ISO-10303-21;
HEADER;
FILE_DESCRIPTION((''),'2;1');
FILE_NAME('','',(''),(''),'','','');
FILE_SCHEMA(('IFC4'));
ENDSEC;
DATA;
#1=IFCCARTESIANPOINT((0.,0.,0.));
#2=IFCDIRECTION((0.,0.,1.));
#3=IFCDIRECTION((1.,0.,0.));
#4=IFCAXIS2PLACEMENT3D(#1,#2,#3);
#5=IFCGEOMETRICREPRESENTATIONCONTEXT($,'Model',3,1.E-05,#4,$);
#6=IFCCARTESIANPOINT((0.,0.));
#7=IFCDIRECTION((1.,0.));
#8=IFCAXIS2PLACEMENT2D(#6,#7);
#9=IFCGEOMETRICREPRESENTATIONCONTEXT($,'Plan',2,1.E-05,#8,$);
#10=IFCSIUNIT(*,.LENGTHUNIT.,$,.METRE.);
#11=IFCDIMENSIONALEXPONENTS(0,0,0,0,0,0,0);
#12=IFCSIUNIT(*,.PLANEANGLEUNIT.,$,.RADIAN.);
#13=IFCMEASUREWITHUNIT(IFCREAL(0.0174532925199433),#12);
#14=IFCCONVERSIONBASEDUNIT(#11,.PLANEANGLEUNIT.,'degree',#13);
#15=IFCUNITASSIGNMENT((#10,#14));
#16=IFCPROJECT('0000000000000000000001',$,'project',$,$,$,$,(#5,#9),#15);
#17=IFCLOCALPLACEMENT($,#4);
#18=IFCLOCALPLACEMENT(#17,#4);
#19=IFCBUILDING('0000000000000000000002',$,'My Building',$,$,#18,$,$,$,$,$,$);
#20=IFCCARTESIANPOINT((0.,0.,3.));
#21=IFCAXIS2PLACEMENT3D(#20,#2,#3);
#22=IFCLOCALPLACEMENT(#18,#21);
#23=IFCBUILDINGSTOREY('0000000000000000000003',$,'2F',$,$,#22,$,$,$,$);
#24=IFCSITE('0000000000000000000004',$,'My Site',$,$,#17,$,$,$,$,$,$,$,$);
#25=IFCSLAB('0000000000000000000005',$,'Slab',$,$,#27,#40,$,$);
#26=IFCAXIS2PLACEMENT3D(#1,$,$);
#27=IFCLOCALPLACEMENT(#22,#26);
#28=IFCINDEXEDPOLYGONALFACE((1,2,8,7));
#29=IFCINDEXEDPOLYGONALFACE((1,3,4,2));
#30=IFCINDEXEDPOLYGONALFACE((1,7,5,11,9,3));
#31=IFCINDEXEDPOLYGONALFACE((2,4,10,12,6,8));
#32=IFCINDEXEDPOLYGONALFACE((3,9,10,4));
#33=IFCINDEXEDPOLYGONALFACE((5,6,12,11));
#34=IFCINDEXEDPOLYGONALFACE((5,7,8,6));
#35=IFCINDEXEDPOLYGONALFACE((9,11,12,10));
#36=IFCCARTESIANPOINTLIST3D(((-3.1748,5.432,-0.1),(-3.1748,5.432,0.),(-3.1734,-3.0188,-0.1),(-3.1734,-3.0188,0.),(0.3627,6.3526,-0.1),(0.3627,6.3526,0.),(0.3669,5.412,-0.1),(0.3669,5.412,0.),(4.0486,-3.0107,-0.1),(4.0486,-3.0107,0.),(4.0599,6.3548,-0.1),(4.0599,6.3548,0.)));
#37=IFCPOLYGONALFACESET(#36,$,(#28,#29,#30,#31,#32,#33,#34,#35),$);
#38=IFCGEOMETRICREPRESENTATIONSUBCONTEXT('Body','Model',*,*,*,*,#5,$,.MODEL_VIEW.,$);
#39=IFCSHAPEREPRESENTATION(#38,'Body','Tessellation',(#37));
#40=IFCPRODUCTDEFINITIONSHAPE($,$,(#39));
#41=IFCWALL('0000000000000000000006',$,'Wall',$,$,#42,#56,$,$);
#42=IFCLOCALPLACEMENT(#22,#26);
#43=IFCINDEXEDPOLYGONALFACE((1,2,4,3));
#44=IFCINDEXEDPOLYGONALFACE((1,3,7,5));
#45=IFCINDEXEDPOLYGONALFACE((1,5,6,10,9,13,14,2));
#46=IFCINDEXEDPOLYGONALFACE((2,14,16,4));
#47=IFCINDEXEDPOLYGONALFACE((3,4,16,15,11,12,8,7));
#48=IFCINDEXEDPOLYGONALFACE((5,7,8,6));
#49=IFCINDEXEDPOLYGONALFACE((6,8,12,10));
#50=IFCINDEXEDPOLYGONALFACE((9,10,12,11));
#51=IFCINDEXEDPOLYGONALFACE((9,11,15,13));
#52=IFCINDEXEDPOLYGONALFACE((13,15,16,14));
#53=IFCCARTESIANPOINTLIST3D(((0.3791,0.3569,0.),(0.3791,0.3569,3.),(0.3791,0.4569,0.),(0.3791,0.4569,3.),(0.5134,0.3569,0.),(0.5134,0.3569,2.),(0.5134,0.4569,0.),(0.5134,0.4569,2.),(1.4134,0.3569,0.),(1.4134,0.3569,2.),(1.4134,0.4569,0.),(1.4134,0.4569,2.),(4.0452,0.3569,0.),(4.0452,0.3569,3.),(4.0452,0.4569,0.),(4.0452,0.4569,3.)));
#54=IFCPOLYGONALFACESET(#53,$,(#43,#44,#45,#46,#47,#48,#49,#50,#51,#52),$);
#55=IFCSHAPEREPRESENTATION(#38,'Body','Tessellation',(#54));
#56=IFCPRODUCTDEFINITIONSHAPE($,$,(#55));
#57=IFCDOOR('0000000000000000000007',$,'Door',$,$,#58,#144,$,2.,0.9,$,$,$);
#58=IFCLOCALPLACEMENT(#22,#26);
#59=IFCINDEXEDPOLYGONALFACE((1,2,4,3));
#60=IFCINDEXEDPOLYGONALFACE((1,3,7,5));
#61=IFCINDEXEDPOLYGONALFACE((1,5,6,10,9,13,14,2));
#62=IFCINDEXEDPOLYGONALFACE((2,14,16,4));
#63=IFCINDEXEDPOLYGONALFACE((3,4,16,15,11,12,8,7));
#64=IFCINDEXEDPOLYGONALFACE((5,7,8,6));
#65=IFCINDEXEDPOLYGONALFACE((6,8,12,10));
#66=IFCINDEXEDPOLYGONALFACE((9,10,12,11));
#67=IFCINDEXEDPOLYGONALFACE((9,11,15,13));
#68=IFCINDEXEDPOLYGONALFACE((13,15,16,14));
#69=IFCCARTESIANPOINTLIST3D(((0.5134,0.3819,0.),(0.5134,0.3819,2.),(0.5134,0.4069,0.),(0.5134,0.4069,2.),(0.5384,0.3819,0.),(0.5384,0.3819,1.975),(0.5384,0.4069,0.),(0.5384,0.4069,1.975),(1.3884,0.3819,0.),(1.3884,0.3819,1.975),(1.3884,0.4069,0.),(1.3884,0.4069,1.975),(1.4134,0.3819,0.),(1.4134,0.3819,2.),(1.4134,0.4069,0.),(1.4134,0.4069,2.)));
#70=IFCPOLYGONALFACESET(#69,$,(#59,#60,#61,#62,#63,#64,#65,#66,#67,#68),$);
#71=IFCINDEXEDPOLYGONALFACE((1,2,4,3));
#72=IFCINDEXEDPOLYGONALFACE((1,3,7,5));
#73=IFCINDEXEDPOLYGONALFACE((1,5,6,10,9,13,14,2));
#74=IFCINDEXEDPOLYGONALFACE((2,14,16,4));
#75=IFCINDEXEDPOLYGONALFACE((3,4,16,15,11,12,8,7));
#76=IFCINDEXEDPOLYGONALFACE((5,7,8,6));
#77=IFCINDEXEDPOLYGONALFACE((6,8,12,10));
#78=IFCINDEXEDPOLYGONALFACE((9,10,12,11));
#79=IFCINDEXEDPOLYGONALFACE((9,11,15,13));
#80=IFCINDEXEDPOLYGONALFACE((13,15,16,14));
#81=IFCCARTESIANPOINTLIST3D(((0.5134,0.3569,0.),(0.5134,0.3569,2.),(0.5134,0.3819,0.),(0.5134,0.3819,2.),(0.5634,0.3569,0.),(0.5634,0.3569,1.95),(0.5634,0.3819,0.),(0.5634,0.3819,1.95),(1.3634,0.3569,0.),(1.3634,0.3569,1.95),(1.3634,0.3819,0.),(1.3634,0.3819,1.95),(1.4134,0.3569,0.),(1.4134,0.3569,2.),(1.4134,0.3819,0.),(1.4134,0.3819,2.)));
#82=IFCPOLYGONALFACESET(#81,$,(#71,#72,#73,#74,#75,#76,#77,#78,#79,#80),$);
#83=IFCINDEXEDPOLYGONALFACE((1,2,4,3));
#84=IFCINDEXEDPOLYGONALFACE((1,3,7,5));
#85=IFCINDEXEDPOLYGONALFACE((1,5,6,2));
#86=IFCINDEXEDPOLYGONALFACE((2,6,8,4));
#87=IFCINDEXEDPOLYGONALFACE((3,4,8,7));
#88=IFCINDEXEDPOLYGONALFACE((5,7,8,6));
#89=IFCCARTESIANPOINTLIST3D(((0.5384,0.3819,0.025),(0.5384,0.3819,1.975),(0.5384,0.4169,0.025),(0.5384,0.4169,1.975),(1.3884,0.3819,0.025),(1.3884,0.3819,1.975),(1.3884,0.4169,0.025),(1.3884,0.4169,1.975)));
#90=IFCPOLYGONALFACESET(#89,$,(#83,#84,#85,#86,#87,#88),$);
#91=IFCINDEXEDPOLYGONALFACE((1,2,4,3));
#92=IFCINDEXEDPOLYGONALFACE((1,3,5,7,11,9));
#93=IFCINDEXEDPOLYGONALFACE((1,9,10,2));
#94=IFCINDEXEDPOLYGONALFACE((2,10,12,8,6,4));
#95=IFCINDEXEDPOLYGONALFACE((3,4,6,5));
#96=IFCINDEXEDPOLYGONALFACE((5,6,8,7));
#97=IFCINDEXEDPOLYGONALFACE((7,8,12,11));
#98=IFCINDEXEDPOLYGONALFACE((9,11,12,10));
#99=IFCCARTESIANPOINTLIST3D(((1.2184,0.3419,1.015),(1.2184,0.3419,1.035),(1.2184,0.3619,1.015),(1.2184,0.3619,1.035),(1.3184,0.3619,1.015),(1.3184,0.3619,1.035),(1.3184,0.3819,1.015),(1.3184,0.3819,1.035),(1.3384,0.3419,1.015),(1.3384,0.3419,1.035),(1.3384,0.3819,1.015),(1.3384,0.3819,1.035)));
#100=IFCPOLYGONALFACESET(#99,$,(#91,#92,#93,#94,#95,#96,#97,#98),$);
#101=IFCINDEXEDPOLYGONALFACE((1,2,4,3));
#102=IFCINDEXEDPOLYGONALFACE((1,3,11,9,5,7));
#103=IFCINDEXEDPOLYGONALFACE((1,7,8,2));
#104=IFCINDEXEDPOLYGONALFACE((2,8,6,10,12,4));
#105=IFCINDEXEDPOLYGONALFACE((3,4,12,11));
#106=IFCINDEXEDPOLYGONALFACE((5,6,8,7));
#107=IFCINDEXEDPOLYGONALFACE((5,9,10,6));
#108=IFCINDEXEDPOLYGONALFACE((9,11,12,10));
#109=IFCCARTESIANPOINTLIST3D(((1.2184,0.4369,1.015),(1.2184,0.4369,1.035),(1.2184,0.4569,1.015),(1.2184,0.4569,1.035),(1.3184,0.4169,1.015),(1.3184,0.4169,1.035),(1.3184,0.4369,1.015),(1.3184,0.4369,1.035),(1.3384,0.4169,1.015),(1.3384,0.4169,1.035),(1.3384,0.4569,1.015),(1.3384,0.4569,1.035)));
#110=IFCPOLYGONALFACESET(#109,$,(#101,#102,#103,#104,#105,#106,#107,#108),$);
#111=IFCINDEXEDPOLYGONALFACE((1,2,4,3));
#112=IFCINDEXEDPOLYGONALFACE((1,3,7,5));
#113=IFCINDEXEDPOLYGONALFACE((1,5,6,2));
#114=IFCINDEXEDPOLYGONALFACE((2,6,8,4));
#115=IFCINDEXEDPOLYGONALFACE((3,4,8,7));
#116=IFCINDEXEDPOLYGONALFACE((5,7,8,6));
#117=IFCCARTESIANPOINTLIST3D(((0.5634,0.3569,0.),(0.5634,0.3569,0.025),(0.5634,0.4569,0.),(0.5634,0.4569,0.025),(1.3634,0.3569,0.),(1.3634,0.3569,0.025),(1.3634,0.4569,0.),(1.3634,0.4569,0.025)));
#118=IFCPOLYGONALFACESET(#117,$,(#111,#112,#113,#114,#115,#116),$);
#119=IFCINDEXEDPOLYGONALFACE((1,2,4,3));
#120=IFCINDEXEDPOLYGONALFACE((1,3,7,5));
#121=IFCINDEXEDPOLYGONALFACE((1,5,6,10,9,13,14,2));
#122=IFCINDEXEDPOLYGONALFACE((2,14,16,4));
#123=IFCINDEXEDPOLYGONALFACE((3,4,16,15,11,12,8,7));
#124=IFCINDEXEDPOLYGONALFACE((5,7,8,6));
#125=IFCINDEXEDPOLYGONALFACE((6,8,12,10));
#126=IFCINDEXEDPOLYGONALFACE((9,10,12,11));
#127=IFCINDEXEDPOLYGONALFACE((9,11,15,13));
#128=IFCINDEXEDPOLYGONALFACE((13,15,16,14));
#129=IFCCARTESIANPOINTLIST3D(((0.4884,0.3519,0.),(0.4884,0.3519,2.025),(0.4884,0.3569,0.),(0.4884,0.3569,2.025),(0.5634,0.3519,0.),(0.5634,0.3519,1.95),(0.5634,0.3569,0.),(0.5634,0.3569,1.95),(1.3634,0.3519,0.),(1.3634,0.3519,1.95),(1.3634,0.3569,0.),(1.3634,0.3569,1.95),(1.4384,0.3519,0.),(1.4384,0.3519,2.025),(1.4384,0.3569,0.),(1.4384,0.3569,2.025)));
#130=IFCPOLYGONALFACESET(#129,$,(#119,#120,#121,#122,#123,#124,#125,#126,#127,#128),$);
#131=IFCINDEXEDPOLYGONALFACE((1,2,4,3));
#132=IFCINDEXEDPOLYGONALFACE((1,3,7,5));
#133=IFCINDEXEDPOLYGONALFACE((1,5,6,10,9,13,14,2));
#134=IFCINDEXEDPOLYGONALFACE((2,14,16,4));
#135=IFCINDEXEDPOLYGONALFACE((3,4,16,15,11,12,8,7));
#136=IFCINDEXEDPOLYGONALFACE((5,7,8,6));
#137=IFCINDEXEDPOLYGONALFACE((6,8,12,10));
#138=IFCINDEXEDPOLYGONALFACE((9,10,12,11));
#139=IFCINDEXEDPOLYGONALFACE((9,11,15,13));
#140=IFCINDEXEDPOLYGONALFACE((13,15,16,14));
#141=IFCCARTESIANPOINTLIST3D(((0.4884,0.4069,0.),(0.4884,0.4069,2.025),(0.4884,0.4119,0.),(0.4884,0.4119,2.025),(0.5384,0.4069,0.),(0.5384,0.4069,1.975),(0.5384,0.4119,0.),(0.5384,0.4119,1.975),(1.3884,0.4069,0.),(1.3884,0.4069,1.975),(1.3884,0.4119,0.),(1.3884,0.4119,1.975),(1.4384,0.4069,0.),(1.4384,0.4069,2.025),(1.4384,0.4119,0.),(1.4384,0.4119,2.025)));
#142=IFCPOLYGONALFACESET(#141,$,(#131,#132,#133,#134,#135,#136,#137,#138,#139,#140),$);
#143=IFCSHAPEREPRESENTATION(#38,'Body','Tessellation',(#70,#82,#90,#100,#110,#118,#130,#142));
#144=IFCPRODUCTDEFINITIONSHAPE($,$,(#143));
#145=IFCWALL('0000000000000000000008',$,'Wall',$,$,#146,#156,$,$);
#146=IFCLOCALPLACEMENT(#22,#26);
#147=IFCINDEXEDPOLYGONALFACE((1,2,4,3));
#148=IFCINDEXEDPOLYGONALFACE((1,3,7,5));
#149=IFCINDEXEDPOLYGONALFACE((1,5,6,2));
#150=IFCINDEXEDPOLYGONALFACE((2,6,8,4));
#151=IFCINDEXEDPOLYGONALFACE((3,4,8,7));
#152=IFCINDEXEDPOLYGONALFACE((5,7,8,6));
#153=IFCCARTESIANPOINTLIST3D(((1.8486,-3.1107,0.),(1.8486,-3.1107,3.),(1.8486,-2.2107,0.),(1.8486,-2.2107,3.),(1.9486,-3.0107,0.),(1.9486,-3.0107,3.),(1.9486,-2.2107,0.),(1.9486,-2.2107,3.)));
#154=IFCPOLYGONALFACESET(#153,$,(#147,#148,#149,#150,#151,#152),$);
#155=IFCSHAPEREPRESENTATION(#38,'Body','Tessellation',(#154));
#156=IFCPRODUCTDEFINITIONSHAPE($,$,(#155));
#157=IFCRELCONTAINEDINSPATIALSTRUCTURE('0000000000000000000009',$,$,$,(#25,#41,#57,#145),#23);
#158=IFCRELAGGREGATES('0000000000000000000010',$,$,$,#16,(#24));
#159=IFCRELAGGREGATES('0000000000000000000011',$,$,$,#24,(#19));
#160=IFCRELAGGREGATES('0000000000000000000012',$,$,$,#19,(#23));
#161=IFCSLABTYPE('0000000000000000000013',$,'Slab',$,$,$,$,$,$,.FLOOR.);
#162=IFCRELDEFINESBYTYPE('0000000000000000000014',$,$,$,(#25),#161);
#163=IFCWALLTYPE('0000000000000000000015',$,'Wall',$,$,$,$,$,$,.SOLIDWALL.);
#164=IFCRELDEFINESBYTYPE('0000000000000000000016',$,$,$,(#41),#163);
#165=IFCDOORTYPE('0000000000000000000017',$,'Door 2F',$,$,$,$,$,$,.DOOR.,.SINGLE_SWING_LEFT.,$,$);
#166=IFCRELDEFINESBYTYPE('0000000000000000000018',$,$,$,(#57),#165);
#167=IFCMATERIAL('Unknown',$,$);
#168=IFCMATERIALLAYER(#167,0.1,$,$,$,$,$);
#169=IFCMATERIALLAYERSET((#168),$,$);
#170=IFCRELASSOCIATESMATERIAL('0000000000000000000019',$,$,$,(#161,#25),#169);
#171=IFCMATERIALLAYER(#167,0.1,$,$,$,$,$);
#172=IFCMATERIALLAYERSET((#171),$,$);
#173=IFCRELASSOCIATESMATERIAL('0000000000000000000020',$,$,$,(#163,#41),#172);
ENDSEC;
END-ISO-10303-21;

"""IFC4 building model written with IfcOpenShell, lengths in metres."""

from ifc_helpers import new_model, entity, si_unit, converted_unit, frame, origin_with_axes, origin_2d_with_axis, place, context, subcontext, project, spatial, line, indexed_curve, outline, extrude, shape, source, transform, mapped, material, layer, layer_set, layer_usage, type_object, type_shapes, element, fill, save


model = new_model("IFC4")

# Units and contexts
model_context = context("Model", 3, precision=1e-05, world=origin_with_axes())
plan_context = context("Plan", 2, precision=1e-05, world=origin_2d_with_axis())
body_context_1 = subcontext(model_context, "Body", "Model", "MODEL_VIEW")
body_context_2 = subcontext(plan_context, "Body", "Plan", "PLAN_VIEW")
ifc_project = project(units=[si_unit("LENGTHUNIT", "METRE"), converted_unit("PLANEANGLEUNIT", "degree", entity("IfcReal", 0.0174532925199433), si_unit("PLANEANGLEUNIT", "RADIAN"), dimensions=[0, 0, 0, 0, 0, 0, 0])], contexts=[model_context, plan_context])

# Site, building, storey
site_placement = place(None, origin_with_axes())
site = spatial("IfcSite", under=ifc_project, at=site_placement, Name="My Site")
building_placement = place(site_placement, origin_with_axes())
building = spatial("IfcBuilding", under=site, at=building_placement, Name="My Building")
storey_placement = place(building_placement, frame((0.0, 0.0, 3.0), z_axis=(0.0, 0.0, 1.0), x_axis=(1.0, 0.0, 0.0)))
storey = spatial("IfcBuildingStorey", under=building, at=storey_placement, Name="2F")

# Slab
ifc_material = material(Name="Unknown")
ifc_layer_1 = layer(ifc_material, 0.1)
ifc_layer_set_1 = layer_set([ifc_layer_1])
ifc_layer_usage_1 = layer_usage(ifc_layer_set_1, "AXIS3", "POSITIVE", -0.1)
slab_type = type_object("IfcSlabType", Name="Slab", PredefinedType="FLOOR", material=ifc_layer_set_1)
slab_placement = place(storey_placement, frame((-3.1734, -3.0188, 0.0), z_axis=(0.0, 0.0, 1.0), x_axis=(1.0, 0.0, 0.0)))
element("IfcSlab", 1, at=slab_placement, inside=storey, type_object=slab_type, material=ifc_layer_usage_1, Name="Slab", context=body_context_1, shape_type="SweptSolid", body=[
    extrude(outline(indexed_curve([(0.0, 0.0), (7.222, 0.0081), (7.2333, 9.3736), (3.5362, 9.3714), (3.5403, 8.4309), (-0.0014, 8.4508), (0.0, 0.0)])), frame((0.0, 0.0, -0.1), z_axis=(0.0, 0.0, 1.0), x_axis=(1.0, 0.0, 0.0)), (0.0, 0.0, 1.0), 0.1),
])

# Wall, opening, door
ifc_layer_2 = layer(ifc_material, 0.1)
ifc_layer_set_2 = layer_set([ifc_layer_2])
ifc_layer_usage_2 = layer_usage(ifc_layer_set_2, "AXIS2", "POSITIVE", 0.0)
wall_type = type_object("IfcWallType", Name="Wall", PredefinedType="SOLIDWALL", material=ifc_layer_set_2)
wall_1_placement = place(storey_placement, frame((0.3791, 0.3569, 0.0), z_axis=(0.0, 0.0, 1.0), x_axis=(1.0, 0.0, 0.0)))
wall_1 = element("IfcWall", 2, at=wall_1_placement, inside=storey, type_object=wall_type, material=ifc_layer_usage_2, Name="Wall", context=body_context_1, shape_type="SweptSolid", body=[
    extrude(outline(indexed_curve([(0.0, 0.0), (0.0, 0.1), (3.6661, 0.1), (3.6661, 0.0)], segments=[line(1, 2, 3, 4, 1)])), origin_with_axes(), (0.0, 0.0, 1.0), 3.0),
])
shared_shape_1 = source(origin_with_axes(), body_context_1, "Body", "SweptSolid", [
    extrude(outline(indexed_curve([(0.0, 0.0), (0.9, 0.0), (0.9, 2.0), (0.0, 2.0)], segments=[line(1, 2, 3, 4, 1)])), frame((0.0, -0.6, 0.0), z_axis=(0.0, -1.0, 0.0), x_axis=(1.0, 0.0, 0.0)), (0.0, 0.0, -1.0), 1.2),
])
opening_1_placement = place(wall_1_placement, frame((0.1344, 0.0, 0.0), z_axis=(0.0, 0.0, 1.0), x_axis=(1.0, 0.0, 0.0)))
opening_1 = element("IfcOpeningElement", 3, at=opening_1_placement, cuts=wall_1, PredefinedType="OPENING", context=body_context_1, shape_type="MappedRepresentation", body=[
    mapped(shared_shape_1, transform((0.0, 0.0, 0.0), x_axis=(1.0, 0.0, 0.0), y_axis=(0.0, 1.0, 0.0), z_axis=(0.0, 0.0, 1.0), scale=1.0)),
])
door_type = type_object("IfcDoorType", Name="Door 2F", OperationType="SINGLE_SWING_LEFT", PredefinedType="DOOR")
shared_shape_2 = source(origin_with_axes(), body_context_1, "Body", "SweptSolid", [
    extrude(outline(indexed_curve([(0.0, 0.0), (0.0, 2.0), (0.9, 2.0), (0.9, 0.0), (0.875, 0.0), (0.875, 1.975), (0.025, 1.975), (0.025, 0.0)], segments=[line(1, 2, 3, 4, 5, 6, 7, 8, 1)])), frame((0.0, 0.025, 0.0), z_axis=(0.0, -1.0, 0.0), x_axis=(1.0, 0.0, 0.0)), (0.0, 0.0, -1.0), 0.025),
    extrude(outline(indexed_curve([(0.0, 0.0), (0.0, 2.0), (0.9, 2.0), (0.9, 0.0), (0.85, 0.0), (0.85, 1.95), (0.05, 1.95), (0.05, 0.0)], segments=[line(1, 2, 3, 4, 5, 6, 7, 8, 1)])), frame((0.0, 0.0, 0.0), z_axis=(0.0, -1.0, 0.0), x_axis=(1.0, 0.0, 0.0)), (0.0, 0.0, -1.0), 0.025),
    extrude(outline(indexed_curve([(0.0, 0.0), (0.85, 0.0), (0.85, 0.035), (0.0, 0.035)], segments=[line(1, 2, 3, 4, 1)])), frame((0.025, 0.025, 0.025), z_axis=(0.0, 0.0, 1.0), x_axis=(1.0, 0.0, 0.0)), (0.0, 0.0, 1.0), 1.95),
    extrude(outline(indexed_curve([(0.0, 0.0), (0.0, -0.04), (-0.12, -0.04), (-0.12, -0.02), (-0.02, -0.02), (-0.02, 0.0)], segments=[line(1, 2, 3, 4, 5, 6, 1)])), frame((0.825, 0.025, 1.015), z_axis=(0.0, 0.0, 1.0), x_axis=(1.0, 0.0, 0.0)), (0.0, 0.0, 1.0), 0.02),
    extrude(outline(indexed_curve([(0.0, 0.0), (0.0, 0.04), (-0.12, 0.04), (-0.12, 0.02), (-0.02, 0.02), (-0.02, 0.0)], segments=[line(1, 2, 3, 4, 5, 6, 1)])), frame((0.825, 0.06, 1.015), z_axis=(0.0, 0.0, 1.0), x_axis=(1.0, 0.0, 0.0)), (0.0, 0.0, 1.0), 0.02),
    extrude(outline(indexed_curve([(0.0, 0.0), (0.8, 0.0), (0.8, 0.1), (0.0, 0.1)], segments=[line(1, 2, 3, 4, 1)])), frame((0.05, 0.0, 0.0), z_axis=(0.0, 0.0, 1.0), x_axis=(1.0, 0.0, 0.0)), (0.0, 0.0, 1.0), 0.025),
    extrude(outline(indexed_curve([(0.0, 0.0), (0.0, 2.025), (0.95, 2.025), (0.95, 0.0), (0.875, 0.0), (0.875, 1.95), (0.075, 1.95), (0.075, 0.0)], segments=[line(1, 2, 3, 4, 5, 6, 7, 8, 1)])), frame((-0.025, -0.005, 0.0), z_axis=(0.0, -1.0, 0.0), x_axis=(1.0, 0.0, 0.0)), (0.0, 0.0, -1.0), 0.005),
    extrude(outline(indexed_curve([(0.0, 0.0), (0.0, 2.025), (0.95, 2.025), (0.95, 0.0), (0.9, 0.0), (0.9, 1.975), (0.05, 1.975), (0.05, 0.0)], segments=[line(1, 2, 3, 4, 5, 6, 7, 8, 1)])), frame((-0.025, 0.05, 0.0), z_axis=(0.0, -1.0, 0.0), x_axis=(1.0, 0.0, 0.0)), (0.0, 0.0, -1.0), 0.005),
])
shared_shape_3 = source(origin_with_axes(), body_context_2, "Body", "Curve2D", [
    entity("IfcIndexedPolyCurve", entity("IfcCartesianPointList2D", [[0.0, 0.0], [0.0, 0.05], [0.025, 0.05], [0.025, 0.025], [0.05, 0.025], [0.05, 0.0]]), [entity("IfcLineIndex", [1, 2, 3, 4, 5, 6, 1])]),
    entity("IfcIndexedPolyCurve", entity("IfcCartesianPointList2D", [[0.9, 0.0], [0.9, 0.05], [0.875, 0.05], [0.875, 0.025], [0.85, 0.025], [0.85, 0.0]]), [entity("IfcLineIndex", [1, 2, 3, 4, 5, 6, 1])]),
    entity("IfcTrimmedCurve", entity("IfcEllipse", entity("IfcAxis2Placement2D", entity("IfcCartesianPoint", [0.06, 0.05]), entity("IfcDirection", [1.0, 0.0])), 0.815, 0.85), [entity("IfcCartesianPoint", [0.875, 0.05])], [entity("IfcCartesianPoint", [0.06, 0.9])], True, "CARTESIAN"),
    entity("IfcIndexedPolyCurve", entity("IfcCartesianPointList2D", [[0.025, 0.05], [0.06, 0.05], [0.06, 0.9], [0.025, 0.9]]), [entity("IfcLineIndex", [1, 2, 3, 4, 1])]),
])
type_shapes(door_type, [shared_shape_2, shared_shape_3])
door_1_placement = place(opening_1_placement, frame((0.0, 0.0, 0.0), z_axis=(0.0, 0.0, 1.0), x_axis=(1.0, 0.0, 0.0)))
door_1 = element("IfcDoor", 4, at=door_1_placement, inside=storey, type_object=door_type, Name="Door", OverallHeight=2.0, OverallWidth=0.9, shapes=[
    shape(body_context_1, "Body", "MappedRepresentation", [mapped(shared_shape_2, transform((0.0, 0.0, 0.0), x_axis=(1.0, 0.0, 0.0), y_axis=(0.0, 1.0, 0.0), z_axis=(0.0, 0.0, 1.0), scale=1.0))]),
    shape(body_context_2, "Body", "MappedRepresentation", [mapped(shared_shape_3, transform((0.0, 0.0, 0.0), x_axis=(1.0, 0.0, 0.0), y_axis=(0.0, 1.0, 0.0), z_axis=(0.0, 0.0, 1.0), scale=1.0))]),
])
fill(opening_1, door_1)

# Wall
wall_2_placement = place(storey_placement, frame((1.8486, -2.2107, 0.0), z_axis=(0.0, 0.0, 1.0), x_axis=(0.0, -1.0, 0.0)))
element("IfcWall", 5, at=wall_2_placement, inside=storey, Name="Wall", context=body_context_1, shape_type="SweptSolid", body=[
    extrude(outline(indexed_curve([(0.0, 0.0), (0.0, 0.1), (0.8, 0.1), (0.9, 0.0)], segments=[line(1, 2, 3, 4, 1)])), origin_with_axes(), (0.0, 0.0, 1.0), 3.0),
])

save(model, "model.ifc")
